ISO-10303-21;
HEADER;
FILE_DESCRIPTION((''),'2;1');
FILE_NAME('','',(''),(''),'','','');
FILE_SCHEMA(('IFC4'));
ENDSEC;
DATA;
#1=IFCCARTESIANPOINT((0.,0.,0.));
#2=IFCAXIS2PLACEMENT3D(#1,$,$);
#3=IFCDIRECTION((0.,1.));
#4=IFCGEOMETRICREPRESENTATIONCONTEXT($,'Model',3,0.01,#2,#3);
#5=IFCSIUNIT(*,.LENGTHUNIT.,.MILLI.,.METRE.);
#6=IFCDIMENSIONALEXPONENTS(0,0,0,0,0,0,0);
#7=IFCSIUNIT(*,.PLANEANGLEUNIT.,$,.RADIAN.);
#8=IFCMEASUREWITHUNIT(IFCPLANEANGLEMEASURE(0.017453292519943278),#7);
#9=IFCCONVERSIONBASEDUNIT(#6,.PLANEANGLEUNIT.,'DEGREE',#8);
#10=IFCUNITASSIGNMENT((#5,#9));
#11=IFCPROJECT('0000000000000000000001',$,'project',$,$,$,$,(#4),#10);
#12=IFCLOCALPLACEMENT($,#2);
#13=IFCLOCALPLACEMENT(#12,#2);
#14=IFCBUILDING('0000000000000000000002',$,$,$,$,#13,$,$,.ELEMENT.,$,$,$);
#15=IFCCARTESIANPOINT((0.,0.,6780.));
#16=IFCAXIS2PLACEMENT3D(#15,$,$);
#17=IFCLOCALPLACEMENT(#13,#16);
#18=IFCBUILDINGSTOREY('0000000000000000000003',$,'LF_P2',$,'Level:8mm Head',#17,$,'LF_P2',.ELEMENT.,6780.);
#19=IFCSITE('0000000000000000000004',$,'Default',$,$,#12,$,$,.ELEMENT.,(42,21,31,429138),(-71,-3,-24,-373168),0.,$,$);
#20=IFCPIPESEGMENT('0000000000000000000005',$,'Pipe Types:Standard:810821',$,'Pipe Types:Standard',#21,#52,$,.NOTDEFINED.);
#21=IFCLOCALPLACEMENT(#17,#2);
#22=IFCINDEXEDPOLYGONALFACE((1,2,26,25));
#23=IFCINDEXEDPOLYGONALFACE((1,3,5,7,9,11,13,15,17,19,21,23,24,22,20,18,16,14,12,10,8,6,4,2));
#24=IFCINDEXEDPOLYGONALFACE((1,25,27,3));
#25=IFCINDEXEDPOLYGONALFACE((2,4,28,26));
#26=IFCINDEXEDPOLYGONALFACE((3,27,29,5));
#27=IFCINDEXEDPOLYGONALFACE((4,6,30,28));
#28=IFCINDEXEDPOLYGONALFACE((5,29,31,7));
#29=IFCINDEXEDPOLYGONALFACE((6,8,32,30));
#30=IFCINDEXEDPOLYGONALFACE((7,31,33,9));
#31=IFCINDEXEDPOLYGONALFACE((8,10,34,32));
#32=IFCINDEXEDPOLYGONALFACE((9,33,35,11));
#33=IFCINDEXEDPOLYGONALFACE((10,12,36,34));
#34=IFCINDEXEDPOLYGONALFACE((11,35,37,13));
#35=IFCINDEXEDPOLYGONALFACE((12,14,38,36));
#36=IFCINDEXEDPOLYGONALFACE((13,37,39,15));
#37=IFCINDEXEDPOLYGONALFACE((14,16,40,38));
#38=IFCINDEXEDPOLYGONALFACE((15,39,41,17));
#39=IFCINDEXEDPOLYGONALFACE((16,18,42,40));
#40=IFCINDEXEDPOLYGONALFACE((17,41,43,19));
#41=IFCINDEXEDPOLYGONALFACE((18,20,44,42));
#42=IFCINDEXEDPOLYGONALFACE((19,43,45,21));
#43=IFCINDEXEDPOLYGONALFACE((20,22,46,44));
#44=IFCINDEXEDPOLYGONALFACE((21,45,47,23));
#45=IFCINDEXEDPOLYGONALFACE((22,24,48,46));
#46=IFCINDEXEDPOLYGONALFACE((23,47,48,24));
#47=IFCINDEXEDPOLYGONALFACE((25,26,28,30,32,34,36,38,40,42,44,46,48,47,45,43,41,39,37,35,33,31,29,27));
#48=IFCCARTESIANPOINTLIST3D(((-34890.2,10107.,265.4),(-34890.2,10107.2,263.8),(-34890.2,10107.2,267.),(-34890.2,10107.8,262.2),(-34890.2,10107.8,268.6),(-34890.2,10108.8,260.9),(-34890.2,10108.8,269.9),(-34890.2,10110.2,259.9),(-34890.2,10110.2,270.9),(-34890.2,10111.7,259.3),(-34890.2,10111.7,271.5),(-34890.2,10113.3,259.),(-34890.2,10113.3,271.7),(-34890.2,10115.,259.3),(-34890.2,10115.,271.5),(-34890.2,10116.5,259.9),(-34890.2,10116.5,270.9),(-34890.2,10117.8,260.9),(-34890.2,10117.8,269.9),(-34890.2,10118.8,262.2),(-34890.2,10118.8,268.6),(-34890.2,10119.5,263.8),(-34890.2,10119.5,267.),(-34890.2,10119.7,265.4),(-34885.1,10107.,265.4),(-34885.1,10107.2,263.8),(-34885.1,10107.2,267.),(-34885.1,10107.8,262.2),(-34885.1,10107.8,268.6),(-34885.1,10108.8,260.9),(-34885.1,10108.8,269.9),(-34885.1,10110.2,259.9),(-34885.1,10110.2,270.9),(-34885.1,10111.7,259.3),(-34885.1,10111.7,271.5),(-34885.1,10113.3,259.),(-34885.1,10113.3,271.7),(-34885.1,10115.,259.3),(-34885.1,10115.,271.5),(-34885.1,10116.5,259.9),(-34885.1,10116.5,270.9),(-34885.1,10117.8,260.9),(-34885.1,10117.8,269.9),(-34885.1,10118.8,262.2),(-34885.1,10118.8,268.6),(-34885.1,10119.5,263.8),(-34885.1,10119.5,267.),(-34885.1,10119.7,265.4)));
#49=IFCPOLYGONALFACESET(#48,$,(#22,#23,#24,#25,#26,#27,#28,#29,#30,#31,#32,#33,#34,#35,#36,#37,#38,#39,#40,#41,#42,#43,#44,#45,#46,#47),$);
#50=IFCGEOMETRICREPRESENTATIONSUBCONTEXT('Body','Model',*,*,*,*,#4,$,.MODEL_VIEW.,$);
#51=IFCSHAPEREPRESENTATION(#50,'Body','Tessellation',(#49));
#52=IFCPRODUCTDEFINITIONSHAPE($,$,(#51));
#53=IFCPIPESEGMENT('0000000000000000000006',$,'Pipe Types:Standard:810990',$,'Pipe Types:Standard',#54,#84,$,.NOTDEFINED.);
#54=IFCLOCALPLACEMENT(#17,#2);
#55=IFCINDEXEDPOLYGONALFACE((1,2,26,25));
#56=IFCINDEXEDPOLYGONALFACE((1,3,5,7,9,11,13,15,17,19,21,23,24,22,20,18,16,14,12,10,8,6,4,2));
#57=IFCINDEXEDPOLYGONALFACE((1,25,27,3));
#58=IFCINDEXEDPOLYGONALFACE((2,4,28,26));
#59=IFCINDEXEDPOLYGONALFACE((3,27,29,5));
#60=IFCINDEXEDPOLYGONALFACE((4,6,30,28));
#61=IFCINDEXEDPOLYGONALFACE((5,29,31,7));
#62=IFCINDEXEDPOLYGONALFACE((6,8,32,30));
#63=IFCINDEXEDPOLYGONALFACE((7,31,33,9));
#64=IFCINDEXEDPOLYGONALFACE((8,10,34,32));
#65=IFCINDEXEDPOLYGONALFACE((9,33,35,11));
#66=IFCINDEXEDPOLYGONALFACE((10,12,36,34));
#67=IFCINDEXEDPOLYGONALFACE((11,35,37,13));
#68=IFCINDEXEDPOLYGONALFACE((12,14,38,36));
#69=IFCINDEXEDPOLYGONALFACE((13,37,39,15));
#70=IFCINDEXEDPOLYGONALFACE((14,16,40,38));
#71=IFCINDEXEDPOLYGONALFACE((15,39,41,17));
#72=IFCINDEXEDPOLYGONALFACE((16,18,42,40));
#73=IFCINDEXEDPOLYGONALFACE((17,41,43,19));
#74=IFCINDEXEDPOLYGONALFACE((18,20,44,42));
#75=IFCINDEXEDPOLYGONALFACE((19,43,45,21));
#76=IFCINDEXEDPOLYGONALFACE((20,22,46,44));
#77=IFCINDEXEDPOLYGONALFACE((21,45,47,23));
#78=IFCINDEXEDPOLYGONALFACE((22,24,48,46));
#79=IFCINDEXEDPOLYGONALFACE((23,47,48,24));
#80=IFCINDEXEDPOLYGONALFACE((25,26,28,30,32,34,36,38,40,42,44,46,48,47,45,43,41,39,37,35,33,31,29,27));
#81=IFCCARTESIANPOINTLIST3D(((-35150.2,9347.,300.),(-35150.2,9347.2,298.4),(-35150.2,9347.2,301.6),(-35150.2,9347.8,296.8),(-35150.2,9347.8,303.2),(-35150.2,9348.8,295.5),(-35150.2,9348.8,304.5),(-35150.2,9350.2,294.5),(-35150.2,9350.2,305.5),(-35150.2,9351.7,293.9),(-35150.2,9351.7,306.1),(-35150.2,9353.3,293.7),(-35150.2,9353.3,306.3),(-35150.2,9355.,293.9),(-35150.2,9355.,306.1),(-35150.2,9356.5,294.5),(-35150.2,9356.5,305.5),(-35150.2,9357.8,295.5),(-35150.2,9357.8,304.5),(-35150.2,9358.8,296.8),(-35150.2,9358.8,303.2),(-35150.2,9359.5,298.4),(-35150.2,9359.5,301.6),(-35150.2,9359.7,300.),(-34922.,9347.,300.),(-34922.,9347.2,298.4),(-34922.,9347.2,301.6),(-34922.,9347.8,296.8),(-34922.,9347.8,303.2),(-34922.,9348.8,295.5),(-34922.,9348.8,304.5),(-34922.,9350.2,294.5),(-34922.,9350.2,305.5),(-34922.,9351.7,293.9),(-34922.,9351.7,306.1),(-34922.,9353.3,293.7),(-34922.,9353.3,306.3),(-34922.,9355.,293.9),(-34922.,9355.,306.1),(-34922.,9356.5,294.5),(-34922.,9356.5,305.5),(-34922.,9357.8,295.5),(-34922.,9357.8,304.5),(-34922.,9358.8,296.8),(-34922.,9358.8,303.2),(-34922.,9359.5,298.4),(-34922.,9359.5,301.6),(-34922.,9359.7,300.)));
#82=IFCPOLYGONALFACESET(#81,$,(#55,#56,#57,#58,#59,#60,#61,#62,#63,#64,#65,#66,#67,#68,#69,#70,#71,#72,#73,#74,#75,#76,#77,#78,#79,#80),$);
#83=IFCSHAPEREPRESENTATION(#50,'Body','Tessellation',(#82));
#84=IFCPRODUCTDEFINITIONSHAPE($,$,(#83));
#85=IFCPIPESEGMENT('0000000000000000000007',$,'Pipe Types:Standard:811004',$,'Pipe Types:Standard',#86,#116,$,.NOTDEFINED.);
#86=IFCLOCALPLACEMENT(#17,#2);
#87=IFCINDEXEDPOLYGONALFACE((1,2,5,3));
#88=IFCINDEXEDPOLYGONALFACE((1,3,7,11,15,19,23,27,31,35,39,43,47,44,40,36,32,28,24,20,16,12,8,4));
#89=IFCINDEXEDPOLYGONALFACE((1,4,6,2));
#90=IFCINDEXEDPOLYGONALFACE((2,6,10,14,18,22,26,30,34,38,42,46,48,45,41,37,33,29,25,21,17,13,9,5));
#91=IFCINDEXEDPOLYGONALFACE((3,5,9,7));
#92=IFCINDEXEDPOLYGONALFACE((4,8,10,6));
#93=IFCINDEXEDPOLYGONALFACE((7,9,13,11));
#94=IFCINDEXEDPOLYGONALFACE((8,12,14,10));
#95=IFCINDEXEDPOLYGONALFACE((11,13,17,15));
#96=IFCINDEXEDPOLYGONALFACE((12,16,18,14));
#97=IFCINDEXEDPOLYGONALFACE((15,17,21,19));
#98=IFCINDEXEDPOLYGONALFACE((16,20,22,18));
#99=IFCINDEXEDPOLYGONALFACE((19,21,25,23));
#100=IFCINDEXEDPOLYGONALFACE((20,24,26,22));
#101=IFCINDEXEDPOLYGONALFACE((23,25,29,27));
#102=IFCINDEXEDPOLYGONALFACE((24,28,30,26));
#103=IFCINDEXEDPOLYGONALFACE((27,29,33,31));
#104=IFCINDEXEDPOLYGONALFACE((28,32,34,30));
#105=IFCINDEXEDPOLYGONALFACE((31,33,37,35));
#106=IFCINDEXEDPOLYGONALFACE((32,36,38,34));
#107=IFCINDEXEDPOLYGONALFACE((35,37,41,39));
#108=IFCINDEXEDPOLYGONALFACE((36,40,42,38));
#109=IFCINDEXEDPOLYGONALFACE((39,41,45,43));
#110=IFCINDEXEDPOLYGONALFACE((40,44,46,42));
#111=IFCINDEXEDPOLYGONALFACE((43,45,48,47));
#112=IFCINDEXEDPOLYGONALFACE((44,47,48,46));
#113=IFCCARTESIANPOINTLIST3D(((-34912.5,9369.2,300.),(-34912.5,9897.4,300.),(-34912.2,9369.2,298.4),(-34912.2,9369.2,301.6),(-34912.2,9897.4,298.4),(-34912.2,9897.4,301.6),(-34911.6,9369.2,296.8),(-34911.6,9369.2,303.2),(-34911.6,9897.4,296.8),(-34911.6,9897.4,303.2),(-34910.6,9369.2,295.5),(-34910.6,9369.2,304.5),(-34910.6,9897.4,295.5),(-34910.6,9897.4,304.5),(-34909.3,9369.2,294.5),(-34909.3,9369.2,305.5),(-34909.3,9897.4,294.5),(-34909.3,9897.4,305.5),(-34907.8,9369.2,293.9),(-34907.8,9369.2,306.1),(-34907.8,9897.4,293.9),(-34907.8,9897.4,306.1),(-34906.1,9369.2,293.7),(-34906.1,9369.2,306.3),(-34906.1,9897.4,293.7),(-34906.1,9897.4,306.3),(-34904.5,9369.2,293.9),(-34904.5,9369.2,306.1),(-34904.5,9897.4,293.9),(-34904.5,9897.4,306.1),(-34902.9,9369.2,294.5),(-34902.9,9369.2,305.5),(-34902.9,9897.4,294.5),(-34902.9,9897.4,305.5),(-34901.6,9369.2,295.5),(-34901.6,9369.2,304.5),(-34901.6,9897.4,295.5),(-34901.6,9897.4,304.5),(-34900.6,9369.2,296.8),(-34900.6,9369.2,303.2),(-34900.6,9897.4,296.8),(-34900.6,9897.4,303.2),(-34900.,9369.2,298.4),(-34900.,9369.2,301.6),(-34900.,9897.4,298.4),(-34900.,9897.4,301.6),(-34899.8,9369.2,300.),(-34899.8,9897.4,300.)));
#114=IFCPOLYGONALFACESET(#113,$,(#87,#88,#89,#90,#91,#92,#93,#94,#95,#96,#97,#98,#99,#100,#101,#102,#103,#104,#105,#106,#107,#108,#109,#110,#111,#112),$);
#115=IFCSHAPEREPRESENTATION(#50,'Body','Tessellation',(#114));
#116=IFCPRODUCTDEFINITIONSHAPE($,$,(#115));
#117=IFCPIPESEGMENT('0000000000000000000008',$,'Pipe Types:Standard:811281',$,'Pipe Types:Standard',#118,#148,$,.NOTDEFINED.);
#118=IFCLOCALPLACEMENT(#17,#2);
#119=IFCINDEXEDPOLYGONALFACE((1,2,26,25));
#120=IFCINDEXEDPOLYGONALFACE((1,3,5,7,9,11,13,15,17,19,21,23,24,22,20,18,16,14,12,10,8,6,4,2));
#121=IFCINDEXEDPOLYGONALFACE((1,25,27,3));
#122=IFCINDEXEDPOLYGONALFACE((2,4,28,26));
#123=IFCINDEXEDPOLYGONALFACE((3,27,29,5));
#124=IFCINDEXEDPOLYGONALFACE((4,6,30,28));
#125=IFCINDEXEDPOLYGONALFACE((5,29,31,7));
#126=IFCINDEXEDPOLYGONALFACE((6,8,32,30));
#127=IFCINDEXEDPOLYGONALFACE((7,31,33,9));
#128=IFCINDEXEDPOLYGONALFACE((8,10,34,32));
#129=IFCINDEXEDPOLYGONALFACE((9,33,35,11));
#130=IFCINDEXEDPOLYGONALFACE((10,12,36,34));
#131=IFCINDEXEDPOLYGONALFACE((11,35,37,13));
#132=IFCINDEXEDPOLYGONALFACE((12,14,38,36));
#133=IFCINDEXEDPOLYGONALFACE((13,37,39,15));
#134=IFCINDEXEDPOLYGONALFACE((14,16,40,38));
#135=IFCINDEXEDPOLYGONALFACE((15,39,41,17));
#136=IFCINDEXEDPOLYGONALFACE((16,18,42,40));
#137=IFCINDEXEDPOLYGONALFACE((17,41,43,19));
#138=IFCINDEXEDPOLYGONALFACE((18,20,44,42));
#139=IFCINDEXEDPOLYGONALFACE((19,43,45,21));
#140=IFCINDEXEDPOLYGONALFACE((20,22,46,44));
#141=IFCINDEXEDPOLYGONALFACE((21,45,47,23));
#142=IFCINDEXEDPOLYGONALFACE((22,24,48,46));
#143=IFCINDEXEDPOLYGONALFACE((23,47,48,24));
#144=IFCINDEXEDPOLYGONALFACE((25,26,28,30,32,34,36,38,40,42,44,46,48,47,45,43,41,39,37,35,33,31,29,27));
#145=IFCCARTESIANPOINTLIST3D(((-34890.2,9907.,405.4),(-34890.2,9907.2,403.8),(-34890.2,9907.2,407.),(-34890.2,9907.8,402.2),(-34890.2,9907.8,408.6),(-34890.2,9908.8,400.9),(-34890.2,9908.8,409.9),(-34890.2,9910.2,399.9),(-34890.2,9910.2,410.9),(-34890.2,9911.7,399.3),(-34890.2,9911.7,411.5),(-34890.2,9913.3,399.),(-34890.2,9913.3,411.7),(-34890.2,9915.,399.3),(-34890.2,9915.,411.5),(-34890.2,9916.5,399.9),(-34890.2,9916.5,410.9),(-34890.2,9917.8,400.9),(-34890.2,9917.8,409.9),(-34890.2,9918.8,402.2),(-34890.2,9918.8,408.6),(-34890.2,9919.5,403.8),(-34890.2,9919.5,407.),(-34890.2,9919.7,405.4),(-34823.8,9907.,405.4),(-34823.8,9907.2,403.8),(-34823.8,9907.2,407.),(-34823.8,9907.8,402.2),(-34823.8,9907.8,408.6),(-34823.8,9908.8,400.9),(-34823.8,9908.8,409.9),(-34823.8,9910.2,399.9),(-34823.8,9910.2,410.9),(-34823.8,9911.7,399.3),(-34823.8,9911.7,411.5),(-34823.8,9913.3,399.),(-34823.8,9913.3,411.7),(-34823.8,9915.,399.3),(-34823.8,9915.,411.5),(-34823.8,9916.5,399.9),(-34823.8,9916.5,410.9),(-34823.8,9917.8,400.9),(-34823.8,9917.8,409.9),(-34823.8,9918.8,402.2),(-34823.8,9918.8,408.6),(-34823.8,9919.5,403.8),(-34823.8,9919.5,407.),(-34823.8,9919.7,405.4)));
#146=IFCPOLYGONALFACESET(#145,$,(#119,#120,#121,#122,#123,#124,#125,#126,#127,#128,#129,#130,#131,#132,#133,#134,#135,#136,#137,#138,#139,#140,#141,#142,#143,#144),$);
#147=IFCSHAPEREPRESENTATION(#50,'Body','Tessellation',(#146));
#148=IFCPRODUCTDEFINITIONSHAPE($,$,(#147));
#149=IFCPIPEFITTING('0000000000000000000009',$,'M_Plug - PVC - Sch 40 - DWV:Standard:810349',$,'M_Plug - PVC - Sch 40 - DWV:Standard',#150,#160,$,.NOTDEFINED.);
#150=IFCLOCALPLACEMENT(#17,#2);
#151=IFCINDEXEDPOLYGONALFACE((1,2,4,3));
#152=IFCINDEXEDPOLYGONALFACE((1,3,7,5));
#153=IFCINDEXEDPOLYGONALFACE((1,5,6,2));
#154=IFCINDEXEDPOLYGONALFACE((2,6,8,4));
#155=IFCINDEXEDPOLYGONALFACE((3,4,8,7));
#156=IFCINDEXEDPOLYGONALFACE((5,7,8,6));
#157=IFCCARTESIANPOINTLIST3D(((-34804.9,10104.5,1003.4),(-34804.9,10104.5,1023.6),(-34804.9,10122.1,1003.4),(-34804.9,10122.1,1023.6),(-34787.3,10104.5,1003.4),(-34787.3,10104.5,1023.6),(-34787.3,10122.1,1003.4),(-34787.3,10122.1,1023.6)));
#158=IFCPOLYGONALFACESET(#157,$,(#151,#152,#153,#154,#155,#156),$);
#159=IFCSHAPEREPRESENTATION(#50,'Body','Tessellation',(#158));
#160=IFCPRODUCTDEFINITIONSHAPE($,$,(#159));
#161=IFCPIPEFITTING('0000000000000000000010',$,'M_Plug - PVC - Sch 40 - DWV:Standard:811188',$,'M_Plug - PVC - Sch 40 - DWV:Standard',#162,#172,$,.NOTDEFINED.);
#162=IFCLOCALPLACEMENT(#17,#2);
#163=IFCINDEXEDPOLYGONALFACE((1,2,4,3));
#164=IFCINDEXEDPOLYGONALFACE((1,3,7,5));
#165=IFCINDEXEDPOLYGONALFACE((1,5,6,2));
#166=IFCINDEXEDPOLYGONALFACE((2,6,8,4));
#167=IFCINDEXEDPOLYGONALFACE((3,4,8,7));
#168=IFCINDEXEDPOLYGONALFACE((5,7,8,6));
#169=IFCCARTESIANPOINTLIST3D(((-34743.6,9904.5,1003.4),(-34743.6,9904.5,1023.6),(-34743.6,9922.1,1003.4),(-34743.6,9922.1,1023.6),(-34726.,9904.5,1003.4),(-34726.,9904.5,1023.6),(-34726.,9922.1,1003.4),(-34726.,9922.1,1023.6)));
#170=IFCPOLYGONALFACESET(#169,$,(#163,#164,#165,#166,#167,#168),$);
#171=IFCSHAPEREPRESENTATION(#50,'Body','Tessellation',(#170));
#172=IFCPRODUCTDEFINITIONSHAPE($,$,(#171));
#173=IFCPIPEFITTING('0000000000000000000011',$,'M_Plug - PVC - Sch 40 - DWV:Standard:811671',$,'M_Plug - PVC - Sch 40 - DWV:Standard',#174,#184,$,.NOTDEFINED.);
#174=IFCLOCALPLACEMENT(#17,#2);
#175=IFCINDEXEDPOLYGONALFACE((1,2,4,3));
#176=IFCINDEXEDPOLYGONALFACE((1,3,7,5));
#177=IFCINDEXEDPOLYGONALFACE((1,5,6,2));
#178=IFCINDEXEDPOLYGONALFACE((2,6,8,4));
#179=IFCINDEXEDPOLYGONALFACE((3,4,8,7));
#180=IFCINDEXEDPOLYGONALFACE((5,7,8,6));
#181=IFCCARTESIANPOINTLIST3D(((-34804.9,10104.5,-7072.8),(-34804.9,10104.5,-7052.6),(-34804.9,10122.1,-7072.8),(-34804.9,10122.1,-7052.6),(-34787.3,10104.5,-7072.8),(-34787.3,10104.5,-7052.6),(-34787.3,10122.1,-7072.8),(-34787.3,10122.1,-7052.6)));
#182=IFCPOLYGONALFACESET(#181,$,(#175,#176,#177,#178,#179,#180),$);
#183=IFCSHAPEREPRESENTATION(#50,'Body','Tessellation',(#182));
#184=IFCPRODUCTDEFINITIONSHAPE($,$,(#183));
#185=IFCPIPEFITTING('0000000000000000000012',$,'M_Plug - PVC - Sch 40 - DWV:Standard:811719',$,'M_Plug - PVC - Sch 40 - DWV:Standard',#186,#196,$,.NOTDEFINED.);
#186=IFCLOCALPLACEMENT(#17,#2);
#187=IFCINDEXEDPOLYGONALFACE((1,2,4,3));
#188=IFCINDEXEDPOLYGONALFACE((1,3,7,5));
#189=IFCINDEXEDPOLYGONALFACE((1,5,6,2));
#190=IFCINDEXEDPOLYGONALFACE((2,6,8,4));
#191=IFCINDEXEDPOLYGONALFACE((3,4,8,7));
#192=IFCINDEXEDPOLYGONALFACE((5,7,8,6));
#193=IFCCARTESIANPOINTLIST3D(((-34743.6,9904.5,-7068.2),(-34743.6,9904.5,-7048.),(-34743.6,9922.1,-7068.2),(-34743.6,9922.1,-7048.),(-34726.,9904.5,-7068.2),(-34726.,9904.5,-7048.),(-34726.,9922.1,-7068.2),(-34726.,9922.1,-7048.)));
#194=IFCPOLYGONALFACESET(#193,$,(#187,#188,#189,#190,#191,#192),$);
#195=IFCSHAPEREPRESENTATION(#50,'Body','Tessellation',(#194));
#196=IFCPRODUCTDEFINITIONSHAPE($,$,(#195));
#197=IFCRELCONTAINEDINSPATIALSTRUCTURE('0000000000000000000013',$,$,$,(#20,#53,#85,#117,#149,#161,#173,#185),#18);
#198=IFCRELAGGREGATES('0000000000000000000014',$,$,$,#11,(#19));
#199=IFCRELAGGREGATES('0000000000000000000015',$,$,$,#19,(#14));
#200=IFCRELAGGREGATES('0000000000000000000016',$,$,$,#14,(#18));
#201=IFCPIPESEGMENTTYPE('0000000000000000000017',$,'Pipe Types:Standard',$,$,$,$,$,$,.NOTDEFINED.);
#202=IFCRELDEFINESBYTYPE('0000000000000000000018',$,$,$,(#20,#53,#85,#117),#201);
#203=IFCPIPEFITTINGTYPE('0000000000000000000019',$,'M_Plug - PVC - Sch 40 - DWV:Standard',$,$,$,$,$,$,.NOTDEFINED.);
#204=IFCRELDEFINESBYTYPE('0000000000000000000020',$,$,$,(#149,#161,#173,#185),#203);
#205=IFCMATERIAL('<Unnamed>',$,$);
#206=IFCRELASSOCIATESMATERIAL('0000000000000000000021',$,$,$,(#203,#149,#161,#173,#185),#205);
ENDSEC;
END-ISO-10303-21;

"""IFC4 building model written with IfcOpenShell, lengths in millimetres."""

from ifc_helpers import new_model, entity, si_unit, converted_unit, direction, frame, origin, place, context, subcontext, project, spatial, arc, indexed_curve, outline, extrude, source, transform, mapped, material, type_object, type_shapes, element, save


model = new_model("IFC4")

# Units and contexts
model_context = context("Model", 3, precision=0.01, world=origin(), true_north=direction((0.0, 1.0)))
body_context = subcontext(model_context, "Body", "Model", "MODEL_VIEW")
ifc_project = project(units=[si_unit("LENGTHUNIT", "METRE", prefix="MILLI"), converted_unit("PLANEANGLEUNIT", "DEGREE", entity("IfcPlaneAngleMeasure", 0.017453292519943278), si_unit("PLANEANGLEUNIT", "RADIAN"), dimensions=[0, 0, 0, 0, 0, 0, 0])], contexts=[model_context])

# Site, building, storey
site_placement = place(None, origin())
site = spatial("IfcSite", under=ifc_project, at=site_placement, Name="Default", CompositionType="ELEMENT", RefLatitude=(42, 21, 31, 429138), RefLongitude=(-71, -3, -24, -373168), RefElevation=0.0)
building_placement = place(site_placement, origin())
building = spatial("IfcBuilding", under=site, at=building_placement, CompositionType="ELEMENT")
storey_placement = place(building_placement, frame((0.0, 0.0, 6780.0)))
storey = spatial("IfcBuildingStorey", under=building, at=storey_placement, Name="LF_P2", ObjectType="Level:8mm Head", LongName="LF_P2", CompositionType="ELEMENT", Elevation=6780.0)

# Pipe segments
pipe_segment_type_1 = type_object("IfcPipeSegmentType", Name="Pipe Types:Standard", PredefinedType="NOTDEFINED")
pipe_segment_1_placement = place(storey_placement, origin())
element("IfcPipeSegment", 1, at=pipe_segment_1_placement, inside=storey, type_object=pipe_segment_type_1, Name="Pipe Types:Standard:810821", ObjectType="Pipe Types:Standard", PredefinedType="NOTDEFINED", context=body_context, shape_type="SweptSolid", body=[
    extrude(outline(indexed_curve([(6.3, 0.0), (4.5, 4.5), (0.0, 6.3), (-4.5, 4.5), (-6.4, 0.0), (-4.5, -4.5), (0.0, -6.4), (4.5, -4.5)], segments=[arc(1, 2, 3), arc(3, 4, 5), arc(5, 6, 7), arc(7, 8, 1)], self_intersect=False)), frame((-34890.2, 10113.3, 265.4), z_axis=(1.0, 0.0, 0.0), x_axis=(0.0, 1.0, 0.0)), (0.0, 0.0, 1.0), 5.1),
])
pipe_segment_2_placement = place(storey_placement, origin())
element("IfcPipeSegment", 2, at=pipe_segment_2_placement, inside=storey, type_object=pipe_segment_type_1, Name="Pipe Types:Standard:810990", ObjectType="Pipe Types:Standard", PredefinedType="NOTDEFINED", context=body_context, shape_type="SweptSolid", body=[
    extrude(outline(indexed_curve([(6.3, 0.0), (4.5, 4.5), (0.0, 6.3), (-4.5, 4.5), (-6.3, 0.0), (-4.5, -4.5), (0.0, -6.3), (4.5, -4.5)], segments=[arc(1, 2, 3), arc(3, 4, 5), arc(5, 6, 7), arc(7, 8, 1)], self_intersect=False)), frame((-35150.2, 9353.3, 300.0), z_axis=(1.0, 0.0, 0.0), x_axis=(0.0, -1.0, 0.0)), (0.0, 0.0, 1.0), 228.2),
])
pipe_segment_3_placement = place(storey_placement, origin())
element("IfcPipeSegment", 3, at=pipe_segment_3_placement, inside=storey, type_object=pipe_segment_type_1, Name="Pipe Types:Standard:811004", ObjectType="Pipe Types:Standard", PredefinedType="NOTDEFINED", context=body_context, shape_type="SweptSolid", body=[
    extrude(outline(indexed_curve([(6.3, 0.0), (4.5, 4.5), (0.0, 6.3), (-4.5, 4.5), (-6.3, 0.0), (-4.5, -4.5), (0.0, -6.3), (4.5, -4.5)], segments=[arc(1, 2, 3), arc(3, 4, 5), arc(5, 6, 7), arc(7, 8, 1)], self_intersect=False)), frame((-34906.1, 9369.2, 300.0), z_axis=(0.0, 1.0, 0.0), x_axis=(1.0, 0.0, 0.0)), (0.0, 0.0, 1.0), 528.2),
])
pipe_segment_4_placement = place(storey_placement, origin())
element("IfcPipeSegment", 4, at=pipe_segment_4_placement, inside=storey, type_object=pipe_segment_type_1, Name="Pipe Types:Standard:811281", ObjectType="Pipe Types:Standard", PredefinedType="NOTDEFINED", context=body_context, shape_type="SweptSolid", body=[
    extrude(outline(indexed_curve([(6.4, 0.0), (4.5, 4.5), (0.0, 6.3), (-4.5, 4.5), (-6.4, 0.0), (-4.5, -4.5), (0.0, -6.3), (4.5, -4.5)], segments=[arc(1, 2, 3), arc(3, 4, 5), arc(5, 6, 7), arc(7, 8, 1)], self_intersect=False)), frame((-34890.2, 9913.3, 405.4), z_axis=(1.0, 0.0, 0.0), x_axis=(0.0, -1.0, 0.0)), (0.0, 0.0, 1.0), 66.4),
])

# Pipe fittings
ifc_material = material(Name="<Unnamed>")
pipe_fitting_type = type_object("IfcPipeFittingType", Name="M_Plug - PVC - Sch 40 - DWV:Standard", PredefinedType="NOTDEFINED", material=ifc_material)
shared_shape = source(origin(), body_context, "Body", "SweptSolid", [
    extrude(outline(indexed_curve([(-10.1, -8.8), (10.1, -8.8), (10.1, 8.8), (-10.1, 8.8), (-10.1, -8.8)], self_intersect=False)), frame((10.1, 0.0, -8.8), z_axis=(0.0, 0.0, 1.0), x_axis=(-1.0, 0.0, 0.0)), (0.0, 0.0, 1.0), 17.6),
])
type_shapes(pipe_fitting_type, [shared_shape])
for number, where, z_axis, x_axis, name in (
    (5, (-34796.1, 10113.3, 1003.4), (1.0, 0.0, 0.0), (0.0, 0.0, 1.0), "M_Plug - PVC - Sch 40 - DWV:Standard:810349"),
    (6, (-34734.8, 9913.3, 1003.4), (1.0, 0.0, 0.0), (0.0, 0.0, 1.0), "M_Plug - PVC - Sch 40 - DWV:Standard:811188"),
    (7, (-34796.1, 10113.3, -7052.6), (1.0, 0.0, 0.0), (0.0, 0.0, -1.0), "M_Plug - PVC - Sch 40 - DWV:Standard:811671"),
    (8, (-34734.8, 9913.3, -7048.0), (1.0, 0.0, 0.0), (0.0, 0.0, -1.0), "M_Plug - PVC - Sch 40 - DWV:Standard:811719"),
):
    element("IfcPipeFitting", number, at=place(storey_placement, frame(where, z_axis=z_axis, x_axis=x_axis)), inside=storey, type_object=pipe_fitting_type, material=ifc_material, Name=name, ObjectType="M_Plug - PVC - Sch 40 - DWV:Standard", PredefinedType="NOTDEFINED", context=body_context, shape_type="MappedRepresentation", body=[
        mapped(shared_shape, transform((0.0, 0.0, 0.0), scale=1.0)),
    ])

save(model, "model.ifc")
